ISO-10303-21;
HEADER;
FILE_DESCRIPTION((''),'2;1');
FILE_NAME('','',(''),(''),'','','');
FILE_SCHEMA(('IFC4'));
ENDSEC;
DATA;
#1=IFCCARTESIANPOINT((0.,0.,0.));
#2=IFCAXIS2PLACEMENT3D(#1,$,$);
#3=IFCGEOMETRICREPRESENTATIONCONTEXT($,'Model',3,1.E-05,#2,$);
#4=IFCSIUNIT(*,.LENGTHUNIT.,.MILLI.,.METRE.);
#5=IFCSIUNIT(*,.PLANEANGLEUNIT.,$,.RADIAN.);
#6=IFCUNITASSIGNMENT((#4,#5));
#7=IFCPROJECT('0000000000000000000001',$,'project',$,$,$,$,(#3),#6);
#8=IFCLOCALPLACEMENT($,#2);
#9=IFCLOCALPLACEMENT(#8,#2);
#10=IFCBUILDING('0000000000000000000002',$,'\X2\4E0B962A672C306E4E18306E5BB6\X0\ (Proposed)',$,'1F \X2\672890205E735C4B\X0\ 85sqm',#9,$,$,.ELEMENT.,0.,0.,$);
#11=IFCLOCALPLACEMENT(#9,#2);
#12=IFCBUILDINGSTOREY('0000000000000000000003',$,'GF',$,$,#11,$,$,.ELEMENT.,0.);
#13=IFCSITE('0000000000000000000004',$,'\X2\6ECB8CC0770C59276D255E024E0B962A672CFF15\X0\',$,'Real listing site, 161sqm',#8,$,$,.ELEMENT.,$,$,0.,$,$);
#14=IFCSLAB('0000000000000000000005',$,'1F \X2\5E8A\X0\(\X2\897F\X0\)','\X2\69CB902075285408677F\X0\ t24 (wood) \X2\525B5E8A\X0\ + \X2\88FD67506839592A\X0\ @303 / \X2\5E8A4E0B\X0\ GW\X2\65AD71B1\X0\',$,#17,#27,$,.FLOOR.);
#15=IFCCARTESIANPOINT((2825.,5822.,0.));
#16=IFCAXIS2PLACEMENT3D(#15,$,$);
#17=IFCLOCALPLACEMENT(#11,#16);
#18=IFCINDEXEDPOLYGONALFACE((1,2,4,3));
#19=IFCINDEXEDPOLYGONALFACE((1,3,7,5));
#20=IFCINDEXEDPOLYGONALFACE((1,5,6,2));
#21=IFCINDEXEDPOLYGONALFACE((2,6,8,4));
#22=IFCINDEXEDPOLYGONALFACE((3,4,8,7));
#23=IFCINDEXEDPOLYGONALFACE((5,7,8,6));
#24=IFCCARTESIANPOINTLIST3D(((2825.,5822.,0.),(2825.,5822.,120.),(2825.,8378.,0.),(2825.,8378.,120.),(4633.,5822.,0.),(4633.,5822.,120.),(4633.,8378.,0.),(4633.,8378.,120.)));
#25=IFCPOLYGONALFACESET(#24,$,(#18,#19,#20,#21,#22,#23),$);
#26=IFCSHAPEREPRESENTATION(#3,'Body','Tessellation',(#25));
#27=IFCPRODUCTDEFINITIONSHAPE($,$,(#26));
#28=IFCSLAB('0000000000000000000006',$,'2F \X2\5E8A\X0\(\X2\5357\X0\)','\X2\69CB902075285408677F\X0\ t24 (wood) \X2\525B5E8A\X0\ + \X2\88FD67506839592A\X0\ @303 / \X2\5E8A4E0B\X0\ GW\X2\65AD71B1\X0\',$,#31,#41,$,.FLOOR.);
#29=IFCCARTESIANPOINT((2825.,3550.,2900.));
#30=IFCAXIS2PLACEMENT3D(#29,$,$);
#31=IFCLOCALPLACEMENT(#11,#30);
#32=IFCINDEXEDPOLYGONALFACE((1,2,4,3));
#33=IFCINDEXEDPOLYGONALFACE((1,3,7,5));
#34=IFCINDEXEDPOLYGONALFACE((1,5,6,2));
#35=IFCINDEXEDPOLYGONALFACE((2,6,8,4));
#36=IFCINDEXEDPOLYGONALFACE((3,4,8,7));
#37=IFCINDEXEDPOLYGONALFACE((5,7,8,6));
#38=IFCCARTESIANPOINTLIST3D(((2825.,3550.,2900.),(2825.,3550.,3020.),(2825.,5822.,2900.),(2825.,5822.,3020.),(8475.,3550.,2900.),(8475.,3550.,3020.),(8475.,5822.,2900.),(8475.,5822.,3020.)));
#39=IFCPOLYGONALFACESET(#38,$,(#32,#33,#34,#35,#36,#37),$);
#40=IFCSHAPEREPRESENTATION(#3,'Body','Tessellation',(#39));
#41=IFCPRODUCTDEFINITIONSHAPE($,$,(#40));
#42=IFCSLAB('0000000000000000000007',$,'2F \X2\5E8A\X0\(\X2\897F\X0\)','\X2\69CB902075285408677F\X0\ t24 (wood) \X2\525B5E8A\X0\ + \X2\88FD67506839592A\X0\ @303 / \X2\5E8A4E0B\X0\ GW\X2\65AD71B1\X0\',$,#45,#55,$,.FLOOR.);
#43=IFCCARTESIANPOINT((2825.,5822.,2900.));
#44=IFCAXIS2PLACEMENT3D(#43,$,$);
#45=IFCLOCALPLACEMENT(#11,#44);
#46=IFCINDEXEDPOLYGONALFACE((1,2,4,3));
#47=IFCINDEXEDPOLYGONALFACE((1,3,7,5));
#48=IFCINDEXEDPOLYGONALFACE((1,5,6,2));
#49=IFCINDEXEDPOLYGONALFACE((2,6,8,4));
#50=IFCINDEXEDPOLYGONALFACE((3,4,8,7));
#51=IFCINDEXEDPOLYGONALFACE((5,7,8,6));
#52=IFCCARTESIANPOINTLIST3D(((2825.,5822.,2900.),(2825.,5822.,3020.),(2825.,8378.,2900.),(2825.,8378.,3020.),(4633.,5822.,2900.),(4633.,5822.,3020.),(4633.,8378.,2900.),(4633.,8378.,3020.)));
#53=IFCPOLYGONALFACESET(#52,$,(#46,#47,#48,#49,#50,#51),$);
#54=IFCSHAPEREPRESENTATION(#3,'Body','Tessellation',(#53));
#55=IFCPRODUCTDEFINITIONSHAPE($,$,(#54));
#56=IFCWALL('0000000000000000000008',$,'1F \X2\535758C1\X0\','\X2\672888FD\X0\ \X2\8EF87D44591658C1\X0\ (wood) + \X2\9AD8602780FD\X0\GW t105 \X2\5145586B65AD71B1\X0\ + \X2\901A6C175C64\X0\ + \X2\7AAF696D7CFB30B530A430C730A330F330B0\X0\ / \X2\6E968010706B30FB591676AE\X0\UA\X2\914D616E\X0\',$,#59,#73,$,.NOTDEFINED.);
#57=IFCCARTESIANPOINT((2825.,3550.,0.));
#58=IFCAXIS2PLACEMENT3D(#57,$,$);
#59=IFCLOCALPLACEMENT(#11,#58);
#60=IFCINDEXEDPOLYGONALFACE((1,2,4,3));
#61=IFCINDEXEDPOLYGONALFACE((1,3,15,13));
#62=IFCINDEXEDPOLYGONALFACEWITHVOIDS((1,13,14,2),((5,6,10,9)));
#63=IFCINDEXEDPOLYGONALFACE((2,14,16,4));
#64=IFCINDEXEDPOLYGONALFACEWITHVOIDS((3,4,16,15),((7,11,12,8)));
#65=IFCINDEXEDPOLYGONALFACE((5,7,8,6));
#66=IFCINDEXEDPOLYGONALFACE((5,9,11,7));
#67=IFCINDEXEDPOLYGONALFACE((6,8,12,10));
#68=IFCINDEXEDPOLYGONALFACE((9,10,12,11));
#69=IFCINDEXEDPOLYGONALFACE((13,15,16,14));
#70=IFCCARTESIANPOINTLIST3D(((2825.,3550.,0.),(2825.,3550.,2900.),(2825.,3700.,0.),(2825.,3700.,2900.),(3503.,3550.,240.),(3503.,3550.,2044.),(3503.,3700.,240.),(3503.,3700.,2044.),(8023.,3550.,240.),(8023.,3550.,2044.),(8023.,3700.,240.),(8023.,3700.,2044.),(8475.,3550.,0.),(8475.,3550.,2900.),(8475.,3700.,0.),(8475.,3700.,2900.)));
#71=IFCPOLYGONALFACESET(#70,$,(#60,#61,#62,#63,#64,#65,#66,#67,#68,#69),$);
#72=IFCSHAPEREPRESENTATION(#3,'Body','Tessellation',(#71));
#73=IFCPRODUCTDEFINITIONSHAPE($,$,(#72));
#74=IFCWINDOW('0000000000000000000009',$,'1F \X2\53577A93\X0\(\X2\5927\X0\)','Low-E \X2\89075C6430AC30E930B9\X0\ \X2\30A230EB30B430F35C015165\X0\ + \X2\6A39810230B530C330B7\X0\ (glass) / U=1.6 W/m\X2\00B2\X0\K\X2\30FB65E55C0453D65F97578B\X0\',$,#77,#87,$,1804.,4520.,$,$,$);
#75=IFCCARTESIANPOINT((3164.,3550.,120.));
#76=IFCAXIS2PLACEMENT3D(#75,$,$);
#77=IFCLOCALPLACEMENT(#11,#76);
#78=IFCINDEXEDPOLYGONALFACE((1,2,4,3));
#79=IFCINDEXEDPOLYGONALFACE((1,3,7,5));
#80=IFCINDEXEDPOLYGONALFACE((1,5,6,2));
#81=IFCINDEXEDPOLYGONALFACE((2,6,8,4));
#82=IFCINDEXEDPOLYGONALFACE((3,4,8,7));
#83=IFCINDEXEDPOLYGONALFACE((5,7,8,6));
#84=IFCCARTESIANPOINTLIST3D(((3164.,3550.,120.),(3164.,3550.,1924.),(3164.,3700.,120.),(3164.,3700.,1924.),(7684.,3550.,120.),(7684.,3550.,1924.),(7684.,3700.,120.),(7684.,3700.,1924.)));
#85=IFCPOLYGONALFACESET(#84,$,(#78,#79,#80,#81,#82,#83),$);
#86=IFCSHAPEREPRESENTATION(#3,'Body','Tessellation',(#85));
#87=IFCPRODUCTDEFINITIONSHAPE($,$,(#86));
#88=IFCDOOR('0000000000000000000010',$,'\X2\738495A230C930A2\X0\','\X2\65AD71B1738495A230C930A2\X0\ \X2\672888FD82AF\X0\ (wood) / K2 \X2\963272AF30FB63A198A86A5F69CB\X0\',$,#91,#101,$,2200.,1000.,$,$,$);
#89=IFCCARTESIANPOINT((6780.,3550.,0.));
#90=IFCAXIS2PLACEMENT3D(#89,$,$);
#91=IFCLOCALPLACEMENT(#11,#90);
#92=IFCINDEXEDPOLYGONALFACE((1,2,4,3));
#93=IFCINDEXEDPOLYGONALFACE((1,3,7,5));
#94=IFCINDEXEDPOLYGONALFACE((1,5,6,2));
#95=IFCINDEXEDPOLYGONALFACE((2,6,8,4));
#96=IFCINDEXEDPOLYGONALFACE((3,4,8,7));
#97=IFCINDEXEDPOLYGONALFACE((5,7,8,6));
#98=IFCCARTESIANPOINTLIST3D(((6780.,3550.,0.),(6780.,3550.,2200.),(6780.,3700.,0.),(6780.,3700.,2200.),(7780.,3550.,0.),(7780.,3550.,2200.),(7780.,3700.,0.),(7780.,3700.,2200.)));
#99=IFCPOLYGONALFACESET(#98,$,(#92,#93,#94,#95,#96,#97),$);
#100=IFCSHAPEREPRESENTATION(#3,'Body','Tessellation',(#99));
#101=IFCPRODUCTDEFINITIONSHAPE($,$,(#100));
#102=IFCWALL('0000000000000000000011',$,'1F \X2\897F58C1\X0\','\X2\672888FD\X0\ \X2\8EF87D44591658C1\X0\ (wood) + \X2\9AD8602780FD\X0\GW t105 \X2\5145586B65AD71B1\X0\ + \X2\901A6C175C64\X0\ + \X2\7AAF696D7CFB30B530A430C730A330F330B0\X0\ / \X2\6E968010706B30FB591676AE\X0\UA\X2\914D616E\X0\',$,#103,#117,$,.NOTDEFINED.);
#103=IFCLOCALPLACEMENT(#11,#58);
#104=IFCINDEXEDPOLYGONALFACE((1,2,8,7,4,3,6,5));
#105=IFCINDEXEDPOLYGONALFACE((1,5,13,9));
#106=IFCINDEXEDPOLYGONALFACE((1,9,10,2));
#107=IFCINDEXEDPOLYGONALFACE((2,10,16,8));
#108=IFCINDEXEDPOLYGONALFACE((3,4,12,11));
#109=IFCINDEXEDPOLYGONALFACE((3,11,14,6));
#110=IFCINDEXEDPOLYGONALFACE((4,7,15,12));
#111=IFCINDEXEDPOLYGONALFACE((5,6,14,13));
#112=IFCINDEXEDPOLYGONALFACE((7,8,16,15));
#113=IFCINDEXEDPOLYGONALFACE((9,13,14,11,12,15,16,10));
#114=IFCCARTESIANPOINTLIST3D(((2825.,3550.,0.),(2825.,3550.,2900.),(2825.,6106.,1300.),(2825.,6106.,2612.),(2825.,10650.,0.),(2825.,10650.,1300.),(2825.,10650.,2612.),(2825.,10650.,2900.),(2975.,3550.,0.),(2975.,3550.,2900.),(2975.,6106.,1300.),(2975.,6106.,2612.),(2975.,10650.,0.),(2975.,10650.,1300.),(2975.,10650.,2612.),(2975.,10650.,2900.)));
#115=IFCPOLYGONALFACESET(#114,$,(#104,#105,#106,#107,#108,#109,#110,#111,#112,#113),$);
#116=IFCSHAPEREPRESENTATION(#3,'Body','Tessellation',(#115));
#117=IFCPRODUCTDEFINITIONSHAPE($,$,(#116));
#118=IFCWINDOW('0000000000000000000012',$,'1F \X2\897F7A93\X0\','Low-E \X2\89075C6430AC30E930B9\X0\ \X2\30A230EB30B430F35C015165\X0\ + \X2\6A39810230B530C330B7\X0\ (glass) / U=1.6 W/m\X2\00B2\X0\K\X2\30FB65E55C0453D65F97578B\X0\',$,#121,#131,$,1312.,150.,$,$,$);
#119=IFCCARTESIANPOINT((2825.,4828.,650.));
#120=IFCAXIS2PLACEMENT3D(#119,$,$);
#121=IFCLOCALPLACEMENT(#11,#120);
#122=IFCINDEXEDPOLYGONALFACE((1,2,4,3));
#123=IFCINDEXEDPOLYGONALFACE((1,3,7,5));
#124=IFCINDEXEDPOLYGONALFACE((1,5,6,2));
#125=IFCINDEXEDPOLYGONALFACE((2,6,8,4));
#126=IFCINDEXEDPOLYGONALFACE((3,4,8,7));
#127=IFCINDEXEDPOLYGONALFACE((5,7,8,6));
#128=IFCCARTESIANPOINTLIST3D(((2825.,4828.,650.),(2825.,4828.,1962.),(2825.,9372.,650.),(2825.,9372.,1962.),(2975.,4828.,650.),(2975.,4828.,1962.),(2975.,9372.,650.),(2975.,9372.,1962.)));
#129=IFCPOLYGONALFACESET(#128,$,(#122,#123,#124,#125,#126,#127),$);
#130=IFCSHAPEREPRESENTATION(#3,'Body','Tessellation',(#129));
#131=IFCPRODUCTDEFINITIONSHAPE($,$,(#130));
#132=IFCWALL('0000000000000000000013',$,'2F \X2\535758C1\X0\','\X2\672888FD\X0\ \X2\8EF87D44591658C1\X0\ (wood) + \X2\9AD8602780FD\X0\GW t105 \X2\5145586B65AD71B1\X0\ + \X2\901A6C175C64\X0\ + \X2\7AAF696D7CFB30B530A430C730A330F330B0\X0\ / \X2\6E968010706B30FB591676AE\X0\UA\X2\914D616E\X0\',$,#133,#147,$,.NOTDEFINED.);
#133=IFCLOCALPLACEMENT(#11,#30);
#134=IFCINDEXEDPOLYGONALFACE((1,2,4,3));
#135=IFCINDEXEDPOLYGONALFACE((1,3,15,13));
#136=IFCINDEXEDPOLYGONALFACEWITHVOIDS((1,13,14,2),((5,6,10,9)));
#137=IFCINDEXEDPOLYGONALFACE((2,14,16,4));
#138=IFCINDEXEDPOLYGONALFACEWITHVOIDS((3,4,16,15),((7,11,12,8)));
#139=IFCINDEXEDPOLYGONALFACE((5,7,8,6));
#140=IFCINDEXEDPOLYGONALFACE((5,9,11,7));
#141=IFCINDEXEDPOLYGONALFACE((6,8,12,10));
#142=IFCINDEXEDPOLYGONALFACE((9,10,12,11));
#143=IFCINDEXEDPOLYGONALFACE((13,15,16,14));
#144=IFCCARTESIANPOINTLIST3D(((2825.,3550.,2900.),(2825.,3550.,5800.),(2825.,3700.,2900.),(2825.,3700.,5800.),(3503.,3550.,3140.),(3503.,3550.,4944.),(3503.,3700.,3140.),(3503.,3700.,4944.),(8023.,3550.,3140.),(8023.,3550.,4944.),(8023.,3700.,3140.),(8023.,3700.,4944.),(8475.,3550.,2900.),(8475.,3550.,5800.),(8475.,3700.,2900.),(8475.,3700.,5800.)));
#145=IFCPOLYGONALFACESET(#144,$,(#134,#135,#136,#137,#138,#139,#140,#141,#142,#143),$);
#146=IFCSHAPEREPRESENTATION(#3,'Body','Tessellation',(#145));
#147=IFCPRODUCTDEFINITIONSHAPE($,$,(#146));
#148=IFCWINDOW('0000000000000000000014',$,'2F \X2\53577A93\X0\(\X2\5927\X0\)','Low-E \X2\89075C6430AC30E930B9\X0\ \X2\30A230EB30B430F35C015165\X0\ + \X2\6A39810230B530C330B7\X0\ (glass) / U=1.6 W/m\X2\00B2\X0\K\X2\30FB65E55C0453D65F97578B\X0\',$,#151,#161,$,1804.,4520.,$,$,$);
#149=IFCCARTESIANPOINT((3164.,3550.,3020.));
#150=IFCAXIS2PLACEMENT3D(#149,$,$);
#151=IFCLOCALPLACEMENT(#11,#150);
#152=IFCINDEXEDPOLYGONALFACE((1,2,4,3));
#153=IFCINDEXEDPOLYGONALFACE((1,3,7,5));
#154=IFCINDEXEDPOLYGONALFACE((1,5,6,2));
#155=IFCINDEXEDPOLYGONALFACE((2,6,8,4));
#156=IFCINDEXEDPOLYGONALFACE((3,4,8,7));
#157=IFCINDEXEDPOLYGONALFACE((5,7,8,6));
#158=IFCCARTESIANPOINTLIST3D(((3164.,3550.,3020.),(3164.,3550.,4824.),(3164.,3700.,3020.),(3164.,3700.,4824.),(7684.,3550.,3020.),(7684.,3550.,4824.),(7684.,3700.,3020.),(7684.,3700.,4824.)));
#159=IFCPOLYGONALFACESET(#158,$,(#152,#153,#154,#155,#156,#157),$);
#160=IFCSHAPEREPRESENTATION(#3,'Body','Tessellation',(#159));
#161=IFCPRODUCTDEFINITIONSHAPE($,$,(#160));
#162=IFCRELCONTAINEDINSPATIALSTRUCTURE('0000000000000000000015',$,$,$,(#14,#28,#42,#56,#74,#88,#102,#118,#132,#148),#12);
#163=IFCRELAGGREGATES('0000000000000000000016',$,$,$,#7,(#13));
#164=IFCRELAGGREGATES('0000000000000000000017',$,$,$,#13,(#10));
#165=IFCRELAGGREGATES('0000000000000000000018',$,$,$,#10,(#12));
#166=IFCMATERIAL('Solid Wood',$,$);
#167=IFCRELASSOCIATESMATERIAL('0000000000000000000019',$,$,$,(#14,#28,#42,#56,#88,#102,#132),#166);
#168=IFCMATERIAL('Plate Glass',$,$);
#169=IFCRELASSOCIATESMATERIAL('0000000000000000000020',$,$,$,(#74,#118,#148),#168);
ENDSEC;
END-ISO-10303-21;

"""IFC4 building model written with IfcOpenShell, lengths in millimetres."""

from ifc_helpers import new_model, si_unit, frame, frame_2d, origin, place, context, project, spatial, rectangle, extrude, material, element, fill, save


model = new_model("IFC4")

# Units and contexts
model_context = context("Model", 3, precision=1e-05, world=origin())
ifc_project = project(units=[si_unit("LENGTHUNIT", "METRE", prefix="MILLI"), si_unit("PLANEANGLEUNIT", "RADIAN")], contexts=[model_context])

# Site, building, storey
site_placement = place(None, origin())
site = spatial("IfcSite", under=ifc_project, at=site_placement, Name="滋賀県大津市下阪本５", ObjectType="Real listing site, 161sqm", CompositionType="ELEMENT", RefElevation=0.0)
building_placement = place(site_placement, origin())
building = spatial("IfcBuilding", under=site, at=building_placement, Name="下阪本の丘の家 (Proposed)", ObjectType="1F 木造平屋 85sqm", CompositionType="ELEMENT", ElevationOfRefHeight=0.0, ElevationOfTerrain=0.0)
storey_placement = place(building_placement, origin())
storey = spatial("IfcBuildingStorey", under=building, at=storey_placement, Name="GF", CompositionType="ELEMENT", Elevation=0.0)

# Slabs
ifc_material_1 = material(Name="Solid Wood")
slab_1_placement = place(storey_placement, frame((2825.0, 5822.0, 0.0)))
element("IfcSlab", 1, at=slab_1_placement, inside=storey, material=ifc_material_1, Name="1F 床(西)", Description="構造用合板 t24 (wood) 剛床 + 製材根太 @303 / 床下 GW断熱", PredefinedType="FLOOR", context=model_context, shape_type="SweptSolid", body=[
    extrude(rectangle(XDim=1808.0, YDim=2556.0, at=frame_2d((904.0, 1278.0))), frame((2825.0, 5822.0, 0.0)), (0.0, 0.0, 1.0), 120.0),
])
slab_2_placement = place(storey_placement, frame((2825.0, 3550.0, 2900.0)))
element("IfcSlab", 2, at=slab_2_placement, inside=storey, material=ifc_material_1, Name="2F 床(南)", Description="構造用合板 t24 (wood) 剛床 + 製材根太 @303 / 床下 GW断熱", PredefinedType="FLOOR", context=model_context, shape_type="SweptSolid", body=[
    extrude(rectangle(XDim=5650.0, YDim=2272.0, at=frame_2d((2825.0, 1136.0))), frame((2825.0, 3550.0, 2900.0)), (0.0, 0.0, 1.0), 120.0),
])
slab_3_placement = place(storey_placement, frame((2825.0, 5822.0, 2900.0)))
element("IfcSlab", 3, at=slab_3_placement, inside=storey, material=ifc_material_1, Name="2F 床(西)", Description="構造用合板 t24 (wood) 剛床 + 製材根太 @303 / 床下 GW断熱", PredefinedType="FLOOR", context=model_context, shape_type="SweptSolid", body=[
    extrude(rectangle(XDim=1808.0, YDim=2556.0, at=frame_2d((904.0, 1278.0))), frame((2825.0, 5822.0, 2900.0)), (0.0, 0.0, 1.0), 120.0),
])

# Wall, openings, window, door
wall_1_placement = place(storey_placement, frame((2825.0, 3550.0, 0.0)))
wall_1 = element("IfcWall", 4, at=wall_1_placement, inside=storey, material=ifc_material_1, Name="1F 南壁", Description="木製 軸組外壁 (wood) + 高性能GW t105 充填断熱 + 通気層 + 窯業系サイディング / 準耐火・外皮UA配慮", PredefinedType="NOTDEFINED", context=model_context, shape_type="SweptSolid", body=[
    extrude(rectangle(XDim=5650.0, YDim=150.0, at=frame_2d((2825.0, 75.0))), frame((2825.0, 3550.0, 0.0)), (0.0, 0.0, 1.0), 2900.0),
])
opening_1_placement = place(storey_placement, frame((3164.0, 3550.0, 120.0)))
opening_1 = element("IfcOpeningElement", 5, at=opening_1_placement, cuts=wall_1, PredefinedType="NOTDEFINED", context=model_context, shape_type="SweptSolid", body=[
    extrude(rectangle(XDim=4520.0, YDim=150.0, at=frame_2d((2260.0, 75.0))), frame((3164.0, 3550.0, 120.0)), (0.0, 0.0, 1.0), 1804.0),
])
opening_2_placement = place(storey_placement, frame((6780.0, 3550.0, 0.0)))
opening_2 = element("IfcOpeningElement", 6, at=opening_2_placement, cuts=wall_1, PredefinedType="NOTDEFINED", context=model_context, shape_type="SweptSolid", body=[
    extrude(rectangle(XDim=1000.0, YDim=150.0, at=frame_2d((500.0, 75.0))), frame((6780.0, 3550.0, 0.0)), (0.0, 0.0, 1.0), 2200.0),
])
ifc_material_2 = material(Name="Plate Glass")
window_1_placement = place(storey_placement, frame((3164.0, 3550.0, 120.0)))
window_1 = element("IfcWindow", 7, at=window_1_placement, inside=storey, material=ifc_material_2, Name="1F 南窓(大)", Description="Low-E 複層ガラス アルゴン封入 + 樹脂サッシ (glass) / U=1.6 W/m²K・日射取得型", OverallHeight=1804.0, OverallWidth=4520.0, context=model_context, shape_type="SweptSolid", body=[
    extrude(rectangle(XDim=4520.0, YDim=150.0, at=frame_2d((2260.0, 75.0))), frame((3164.0, 3550.0, 120.0)), (0.0, 0.0, 1.0), 1804.0),
])
fill(opening_1, window_1)
door_placement = place(storey_placement, frame((6780.0, 3550.0, 0.0)))
door = element("IfcDoor", 8, at=door_placement, inside=storey, material=ifc_material_1, Name="玄関ドア", Description="断熱玄関ドア 木製芯 (wood) / K2 防犯・採風機構", OverallHeight=2200.0, OverallWidth=1000.0, context=model_context, shape_type="SweptSolid", body=[
    extrude(rectangle(XDim=1000.0, YDim=150.0, at=frame_2d((500.0, 75.0))), frame((6780.0, 3550.0, 0.0)), (0.0, 0.0, 1.0), 2200.0),
])
fill(opening_2, door)

# Walls, openings, windows
wall_2_placement = place(storey_placement, frame((2825.0, 3550.0, 0.0)))
wall_2 = element("IfcWall", 9, at=wall_2_placement, inside=storey, material=ifc_material_1, Name="1F 西壁", Description="木製 軸組外壁 (wood) + 高性能GW t105 充填断熱 + 通気層 + 窯業系サイディング / 準耐火・外皮UA配慮", PredefinedType="NOTDEFINED", context=model_context, shape_type="SweptSolid", body=[
    extrude(rectangle(XDim=150.0, YDim=7100.0, at=frame_2d((75.0, 3550.0))), frame((2825.0, 3550.0, 0.0)), (0.0, 0.0, 1.0), 2900.0),
])
opening_3_placement = place(storey_placement, frame((2825.0, 4828.0, 650.0)))
opening_3 = element("IfcOpeningElement", 10, at=opening_3_placement, cuts=wall_2, PredefinedType="NOTDEFINED", context=model_context, shape_type="SweptSolid", body=[
    extrude(rectangle(XDim=150.0, YDim=4544.0, at=frame_2d((75.0, 2272.0))), frame((2825.0, 4828.0, 650.0)), (0.0, 0.0, 1.0), 1312.0),
])
window_2_placement = place(storey_placement, frame((2825.0, 4828.0, 650.0)))
window_2 = element("IfcWindow", 11, at=window_2_placement, inside=storey, material=ifc_material_2, Name="1F 西窓", Description="Low-E 複層ガラス アルゴン封入 + 樹脂サッシ (glass) / U=1.6 W/m²K・日射取得型", OverallHeight=1312.0, OverallWidth=150.0, context=model_context, shape_type="SweptSolid", body=[
    extrude(rectangle(XDim=150.0, YDim=4544.0, at=frame_2d((75.0, 2272.0))), frame((2825.0, 4828.0, 650.0)), (0.0, 0.0, 1.0), 1312.0),
])
fill(opening_3, window_2)
wall_3_placement = place(storey_placement, frame((2825.0, 3550.0, 2900.0)))
wall_3 = element("IfcWall", 12, at=wall_3_placement, inside=storey, material=ifc_material_1, Name="2F 南壁", Description="木製 軸組外壁 (wood) + 高性能GW t105 充填断熱 + 通気層 + 窯業系サイディング / 準耐火・外皮UA配慮", PredefinedType="NOTDEFINED", context=model_context, shape_type="SweptSolid", body=[
    extrude(rectangle(XDim=5650.0, YDim=150.0, at=frame_2d((2825.0, 75.0))), frame((2825.0, 3550.0, 2900.0)), (0.0, 0.0, 1.0), 2900.0),
])
opening_4_placement = place(storey_placement, frame((3164.0, 3550.0, 3020.0)))
opening_4 = element("IfcOpeningElement", 13, at=opening_4_placement, cuts=wall_3, PredefinedType="NOTDEFINED", context=model_context, shape_type="SweptSolid", body=[
    extrude(rectangle(XDim=4520.0, YDim=150.0, at=frame_2d((2260.0, 75.0))), frame((3164.0, 3550.0, 3020.0)), (0.0, 0.0, 1.0), 1804.0),
])
window_3_placement = place(storey_placement, frame((3164.0, 3550.0, 3020.0)))
window_3 = element("IfcWindow", 14, at=window_3_placement, inside=storey, material=ifc_material_2, Name="2F 南窓(大)", Description="Low-E 複層ガラス アルゴン封入 + 樹脂サッシ (glass) / U=1.6 W/m²K・日射取得型", OverallHeight=1804.0, OverallWidth=4520.0, context=model_context, shape_type="SweptSolid", body=[
    extrude(rectangle(XDim=4520.0, YDim=150.0, at=frame_2d((2260.0, 75.0))), frame((3164.0, 3550.0, 3020.0)), (0.0, 0.0, 1.0), 1804.0),
])
fill(opening_4, window_3)

save(model, "model.ifc")
